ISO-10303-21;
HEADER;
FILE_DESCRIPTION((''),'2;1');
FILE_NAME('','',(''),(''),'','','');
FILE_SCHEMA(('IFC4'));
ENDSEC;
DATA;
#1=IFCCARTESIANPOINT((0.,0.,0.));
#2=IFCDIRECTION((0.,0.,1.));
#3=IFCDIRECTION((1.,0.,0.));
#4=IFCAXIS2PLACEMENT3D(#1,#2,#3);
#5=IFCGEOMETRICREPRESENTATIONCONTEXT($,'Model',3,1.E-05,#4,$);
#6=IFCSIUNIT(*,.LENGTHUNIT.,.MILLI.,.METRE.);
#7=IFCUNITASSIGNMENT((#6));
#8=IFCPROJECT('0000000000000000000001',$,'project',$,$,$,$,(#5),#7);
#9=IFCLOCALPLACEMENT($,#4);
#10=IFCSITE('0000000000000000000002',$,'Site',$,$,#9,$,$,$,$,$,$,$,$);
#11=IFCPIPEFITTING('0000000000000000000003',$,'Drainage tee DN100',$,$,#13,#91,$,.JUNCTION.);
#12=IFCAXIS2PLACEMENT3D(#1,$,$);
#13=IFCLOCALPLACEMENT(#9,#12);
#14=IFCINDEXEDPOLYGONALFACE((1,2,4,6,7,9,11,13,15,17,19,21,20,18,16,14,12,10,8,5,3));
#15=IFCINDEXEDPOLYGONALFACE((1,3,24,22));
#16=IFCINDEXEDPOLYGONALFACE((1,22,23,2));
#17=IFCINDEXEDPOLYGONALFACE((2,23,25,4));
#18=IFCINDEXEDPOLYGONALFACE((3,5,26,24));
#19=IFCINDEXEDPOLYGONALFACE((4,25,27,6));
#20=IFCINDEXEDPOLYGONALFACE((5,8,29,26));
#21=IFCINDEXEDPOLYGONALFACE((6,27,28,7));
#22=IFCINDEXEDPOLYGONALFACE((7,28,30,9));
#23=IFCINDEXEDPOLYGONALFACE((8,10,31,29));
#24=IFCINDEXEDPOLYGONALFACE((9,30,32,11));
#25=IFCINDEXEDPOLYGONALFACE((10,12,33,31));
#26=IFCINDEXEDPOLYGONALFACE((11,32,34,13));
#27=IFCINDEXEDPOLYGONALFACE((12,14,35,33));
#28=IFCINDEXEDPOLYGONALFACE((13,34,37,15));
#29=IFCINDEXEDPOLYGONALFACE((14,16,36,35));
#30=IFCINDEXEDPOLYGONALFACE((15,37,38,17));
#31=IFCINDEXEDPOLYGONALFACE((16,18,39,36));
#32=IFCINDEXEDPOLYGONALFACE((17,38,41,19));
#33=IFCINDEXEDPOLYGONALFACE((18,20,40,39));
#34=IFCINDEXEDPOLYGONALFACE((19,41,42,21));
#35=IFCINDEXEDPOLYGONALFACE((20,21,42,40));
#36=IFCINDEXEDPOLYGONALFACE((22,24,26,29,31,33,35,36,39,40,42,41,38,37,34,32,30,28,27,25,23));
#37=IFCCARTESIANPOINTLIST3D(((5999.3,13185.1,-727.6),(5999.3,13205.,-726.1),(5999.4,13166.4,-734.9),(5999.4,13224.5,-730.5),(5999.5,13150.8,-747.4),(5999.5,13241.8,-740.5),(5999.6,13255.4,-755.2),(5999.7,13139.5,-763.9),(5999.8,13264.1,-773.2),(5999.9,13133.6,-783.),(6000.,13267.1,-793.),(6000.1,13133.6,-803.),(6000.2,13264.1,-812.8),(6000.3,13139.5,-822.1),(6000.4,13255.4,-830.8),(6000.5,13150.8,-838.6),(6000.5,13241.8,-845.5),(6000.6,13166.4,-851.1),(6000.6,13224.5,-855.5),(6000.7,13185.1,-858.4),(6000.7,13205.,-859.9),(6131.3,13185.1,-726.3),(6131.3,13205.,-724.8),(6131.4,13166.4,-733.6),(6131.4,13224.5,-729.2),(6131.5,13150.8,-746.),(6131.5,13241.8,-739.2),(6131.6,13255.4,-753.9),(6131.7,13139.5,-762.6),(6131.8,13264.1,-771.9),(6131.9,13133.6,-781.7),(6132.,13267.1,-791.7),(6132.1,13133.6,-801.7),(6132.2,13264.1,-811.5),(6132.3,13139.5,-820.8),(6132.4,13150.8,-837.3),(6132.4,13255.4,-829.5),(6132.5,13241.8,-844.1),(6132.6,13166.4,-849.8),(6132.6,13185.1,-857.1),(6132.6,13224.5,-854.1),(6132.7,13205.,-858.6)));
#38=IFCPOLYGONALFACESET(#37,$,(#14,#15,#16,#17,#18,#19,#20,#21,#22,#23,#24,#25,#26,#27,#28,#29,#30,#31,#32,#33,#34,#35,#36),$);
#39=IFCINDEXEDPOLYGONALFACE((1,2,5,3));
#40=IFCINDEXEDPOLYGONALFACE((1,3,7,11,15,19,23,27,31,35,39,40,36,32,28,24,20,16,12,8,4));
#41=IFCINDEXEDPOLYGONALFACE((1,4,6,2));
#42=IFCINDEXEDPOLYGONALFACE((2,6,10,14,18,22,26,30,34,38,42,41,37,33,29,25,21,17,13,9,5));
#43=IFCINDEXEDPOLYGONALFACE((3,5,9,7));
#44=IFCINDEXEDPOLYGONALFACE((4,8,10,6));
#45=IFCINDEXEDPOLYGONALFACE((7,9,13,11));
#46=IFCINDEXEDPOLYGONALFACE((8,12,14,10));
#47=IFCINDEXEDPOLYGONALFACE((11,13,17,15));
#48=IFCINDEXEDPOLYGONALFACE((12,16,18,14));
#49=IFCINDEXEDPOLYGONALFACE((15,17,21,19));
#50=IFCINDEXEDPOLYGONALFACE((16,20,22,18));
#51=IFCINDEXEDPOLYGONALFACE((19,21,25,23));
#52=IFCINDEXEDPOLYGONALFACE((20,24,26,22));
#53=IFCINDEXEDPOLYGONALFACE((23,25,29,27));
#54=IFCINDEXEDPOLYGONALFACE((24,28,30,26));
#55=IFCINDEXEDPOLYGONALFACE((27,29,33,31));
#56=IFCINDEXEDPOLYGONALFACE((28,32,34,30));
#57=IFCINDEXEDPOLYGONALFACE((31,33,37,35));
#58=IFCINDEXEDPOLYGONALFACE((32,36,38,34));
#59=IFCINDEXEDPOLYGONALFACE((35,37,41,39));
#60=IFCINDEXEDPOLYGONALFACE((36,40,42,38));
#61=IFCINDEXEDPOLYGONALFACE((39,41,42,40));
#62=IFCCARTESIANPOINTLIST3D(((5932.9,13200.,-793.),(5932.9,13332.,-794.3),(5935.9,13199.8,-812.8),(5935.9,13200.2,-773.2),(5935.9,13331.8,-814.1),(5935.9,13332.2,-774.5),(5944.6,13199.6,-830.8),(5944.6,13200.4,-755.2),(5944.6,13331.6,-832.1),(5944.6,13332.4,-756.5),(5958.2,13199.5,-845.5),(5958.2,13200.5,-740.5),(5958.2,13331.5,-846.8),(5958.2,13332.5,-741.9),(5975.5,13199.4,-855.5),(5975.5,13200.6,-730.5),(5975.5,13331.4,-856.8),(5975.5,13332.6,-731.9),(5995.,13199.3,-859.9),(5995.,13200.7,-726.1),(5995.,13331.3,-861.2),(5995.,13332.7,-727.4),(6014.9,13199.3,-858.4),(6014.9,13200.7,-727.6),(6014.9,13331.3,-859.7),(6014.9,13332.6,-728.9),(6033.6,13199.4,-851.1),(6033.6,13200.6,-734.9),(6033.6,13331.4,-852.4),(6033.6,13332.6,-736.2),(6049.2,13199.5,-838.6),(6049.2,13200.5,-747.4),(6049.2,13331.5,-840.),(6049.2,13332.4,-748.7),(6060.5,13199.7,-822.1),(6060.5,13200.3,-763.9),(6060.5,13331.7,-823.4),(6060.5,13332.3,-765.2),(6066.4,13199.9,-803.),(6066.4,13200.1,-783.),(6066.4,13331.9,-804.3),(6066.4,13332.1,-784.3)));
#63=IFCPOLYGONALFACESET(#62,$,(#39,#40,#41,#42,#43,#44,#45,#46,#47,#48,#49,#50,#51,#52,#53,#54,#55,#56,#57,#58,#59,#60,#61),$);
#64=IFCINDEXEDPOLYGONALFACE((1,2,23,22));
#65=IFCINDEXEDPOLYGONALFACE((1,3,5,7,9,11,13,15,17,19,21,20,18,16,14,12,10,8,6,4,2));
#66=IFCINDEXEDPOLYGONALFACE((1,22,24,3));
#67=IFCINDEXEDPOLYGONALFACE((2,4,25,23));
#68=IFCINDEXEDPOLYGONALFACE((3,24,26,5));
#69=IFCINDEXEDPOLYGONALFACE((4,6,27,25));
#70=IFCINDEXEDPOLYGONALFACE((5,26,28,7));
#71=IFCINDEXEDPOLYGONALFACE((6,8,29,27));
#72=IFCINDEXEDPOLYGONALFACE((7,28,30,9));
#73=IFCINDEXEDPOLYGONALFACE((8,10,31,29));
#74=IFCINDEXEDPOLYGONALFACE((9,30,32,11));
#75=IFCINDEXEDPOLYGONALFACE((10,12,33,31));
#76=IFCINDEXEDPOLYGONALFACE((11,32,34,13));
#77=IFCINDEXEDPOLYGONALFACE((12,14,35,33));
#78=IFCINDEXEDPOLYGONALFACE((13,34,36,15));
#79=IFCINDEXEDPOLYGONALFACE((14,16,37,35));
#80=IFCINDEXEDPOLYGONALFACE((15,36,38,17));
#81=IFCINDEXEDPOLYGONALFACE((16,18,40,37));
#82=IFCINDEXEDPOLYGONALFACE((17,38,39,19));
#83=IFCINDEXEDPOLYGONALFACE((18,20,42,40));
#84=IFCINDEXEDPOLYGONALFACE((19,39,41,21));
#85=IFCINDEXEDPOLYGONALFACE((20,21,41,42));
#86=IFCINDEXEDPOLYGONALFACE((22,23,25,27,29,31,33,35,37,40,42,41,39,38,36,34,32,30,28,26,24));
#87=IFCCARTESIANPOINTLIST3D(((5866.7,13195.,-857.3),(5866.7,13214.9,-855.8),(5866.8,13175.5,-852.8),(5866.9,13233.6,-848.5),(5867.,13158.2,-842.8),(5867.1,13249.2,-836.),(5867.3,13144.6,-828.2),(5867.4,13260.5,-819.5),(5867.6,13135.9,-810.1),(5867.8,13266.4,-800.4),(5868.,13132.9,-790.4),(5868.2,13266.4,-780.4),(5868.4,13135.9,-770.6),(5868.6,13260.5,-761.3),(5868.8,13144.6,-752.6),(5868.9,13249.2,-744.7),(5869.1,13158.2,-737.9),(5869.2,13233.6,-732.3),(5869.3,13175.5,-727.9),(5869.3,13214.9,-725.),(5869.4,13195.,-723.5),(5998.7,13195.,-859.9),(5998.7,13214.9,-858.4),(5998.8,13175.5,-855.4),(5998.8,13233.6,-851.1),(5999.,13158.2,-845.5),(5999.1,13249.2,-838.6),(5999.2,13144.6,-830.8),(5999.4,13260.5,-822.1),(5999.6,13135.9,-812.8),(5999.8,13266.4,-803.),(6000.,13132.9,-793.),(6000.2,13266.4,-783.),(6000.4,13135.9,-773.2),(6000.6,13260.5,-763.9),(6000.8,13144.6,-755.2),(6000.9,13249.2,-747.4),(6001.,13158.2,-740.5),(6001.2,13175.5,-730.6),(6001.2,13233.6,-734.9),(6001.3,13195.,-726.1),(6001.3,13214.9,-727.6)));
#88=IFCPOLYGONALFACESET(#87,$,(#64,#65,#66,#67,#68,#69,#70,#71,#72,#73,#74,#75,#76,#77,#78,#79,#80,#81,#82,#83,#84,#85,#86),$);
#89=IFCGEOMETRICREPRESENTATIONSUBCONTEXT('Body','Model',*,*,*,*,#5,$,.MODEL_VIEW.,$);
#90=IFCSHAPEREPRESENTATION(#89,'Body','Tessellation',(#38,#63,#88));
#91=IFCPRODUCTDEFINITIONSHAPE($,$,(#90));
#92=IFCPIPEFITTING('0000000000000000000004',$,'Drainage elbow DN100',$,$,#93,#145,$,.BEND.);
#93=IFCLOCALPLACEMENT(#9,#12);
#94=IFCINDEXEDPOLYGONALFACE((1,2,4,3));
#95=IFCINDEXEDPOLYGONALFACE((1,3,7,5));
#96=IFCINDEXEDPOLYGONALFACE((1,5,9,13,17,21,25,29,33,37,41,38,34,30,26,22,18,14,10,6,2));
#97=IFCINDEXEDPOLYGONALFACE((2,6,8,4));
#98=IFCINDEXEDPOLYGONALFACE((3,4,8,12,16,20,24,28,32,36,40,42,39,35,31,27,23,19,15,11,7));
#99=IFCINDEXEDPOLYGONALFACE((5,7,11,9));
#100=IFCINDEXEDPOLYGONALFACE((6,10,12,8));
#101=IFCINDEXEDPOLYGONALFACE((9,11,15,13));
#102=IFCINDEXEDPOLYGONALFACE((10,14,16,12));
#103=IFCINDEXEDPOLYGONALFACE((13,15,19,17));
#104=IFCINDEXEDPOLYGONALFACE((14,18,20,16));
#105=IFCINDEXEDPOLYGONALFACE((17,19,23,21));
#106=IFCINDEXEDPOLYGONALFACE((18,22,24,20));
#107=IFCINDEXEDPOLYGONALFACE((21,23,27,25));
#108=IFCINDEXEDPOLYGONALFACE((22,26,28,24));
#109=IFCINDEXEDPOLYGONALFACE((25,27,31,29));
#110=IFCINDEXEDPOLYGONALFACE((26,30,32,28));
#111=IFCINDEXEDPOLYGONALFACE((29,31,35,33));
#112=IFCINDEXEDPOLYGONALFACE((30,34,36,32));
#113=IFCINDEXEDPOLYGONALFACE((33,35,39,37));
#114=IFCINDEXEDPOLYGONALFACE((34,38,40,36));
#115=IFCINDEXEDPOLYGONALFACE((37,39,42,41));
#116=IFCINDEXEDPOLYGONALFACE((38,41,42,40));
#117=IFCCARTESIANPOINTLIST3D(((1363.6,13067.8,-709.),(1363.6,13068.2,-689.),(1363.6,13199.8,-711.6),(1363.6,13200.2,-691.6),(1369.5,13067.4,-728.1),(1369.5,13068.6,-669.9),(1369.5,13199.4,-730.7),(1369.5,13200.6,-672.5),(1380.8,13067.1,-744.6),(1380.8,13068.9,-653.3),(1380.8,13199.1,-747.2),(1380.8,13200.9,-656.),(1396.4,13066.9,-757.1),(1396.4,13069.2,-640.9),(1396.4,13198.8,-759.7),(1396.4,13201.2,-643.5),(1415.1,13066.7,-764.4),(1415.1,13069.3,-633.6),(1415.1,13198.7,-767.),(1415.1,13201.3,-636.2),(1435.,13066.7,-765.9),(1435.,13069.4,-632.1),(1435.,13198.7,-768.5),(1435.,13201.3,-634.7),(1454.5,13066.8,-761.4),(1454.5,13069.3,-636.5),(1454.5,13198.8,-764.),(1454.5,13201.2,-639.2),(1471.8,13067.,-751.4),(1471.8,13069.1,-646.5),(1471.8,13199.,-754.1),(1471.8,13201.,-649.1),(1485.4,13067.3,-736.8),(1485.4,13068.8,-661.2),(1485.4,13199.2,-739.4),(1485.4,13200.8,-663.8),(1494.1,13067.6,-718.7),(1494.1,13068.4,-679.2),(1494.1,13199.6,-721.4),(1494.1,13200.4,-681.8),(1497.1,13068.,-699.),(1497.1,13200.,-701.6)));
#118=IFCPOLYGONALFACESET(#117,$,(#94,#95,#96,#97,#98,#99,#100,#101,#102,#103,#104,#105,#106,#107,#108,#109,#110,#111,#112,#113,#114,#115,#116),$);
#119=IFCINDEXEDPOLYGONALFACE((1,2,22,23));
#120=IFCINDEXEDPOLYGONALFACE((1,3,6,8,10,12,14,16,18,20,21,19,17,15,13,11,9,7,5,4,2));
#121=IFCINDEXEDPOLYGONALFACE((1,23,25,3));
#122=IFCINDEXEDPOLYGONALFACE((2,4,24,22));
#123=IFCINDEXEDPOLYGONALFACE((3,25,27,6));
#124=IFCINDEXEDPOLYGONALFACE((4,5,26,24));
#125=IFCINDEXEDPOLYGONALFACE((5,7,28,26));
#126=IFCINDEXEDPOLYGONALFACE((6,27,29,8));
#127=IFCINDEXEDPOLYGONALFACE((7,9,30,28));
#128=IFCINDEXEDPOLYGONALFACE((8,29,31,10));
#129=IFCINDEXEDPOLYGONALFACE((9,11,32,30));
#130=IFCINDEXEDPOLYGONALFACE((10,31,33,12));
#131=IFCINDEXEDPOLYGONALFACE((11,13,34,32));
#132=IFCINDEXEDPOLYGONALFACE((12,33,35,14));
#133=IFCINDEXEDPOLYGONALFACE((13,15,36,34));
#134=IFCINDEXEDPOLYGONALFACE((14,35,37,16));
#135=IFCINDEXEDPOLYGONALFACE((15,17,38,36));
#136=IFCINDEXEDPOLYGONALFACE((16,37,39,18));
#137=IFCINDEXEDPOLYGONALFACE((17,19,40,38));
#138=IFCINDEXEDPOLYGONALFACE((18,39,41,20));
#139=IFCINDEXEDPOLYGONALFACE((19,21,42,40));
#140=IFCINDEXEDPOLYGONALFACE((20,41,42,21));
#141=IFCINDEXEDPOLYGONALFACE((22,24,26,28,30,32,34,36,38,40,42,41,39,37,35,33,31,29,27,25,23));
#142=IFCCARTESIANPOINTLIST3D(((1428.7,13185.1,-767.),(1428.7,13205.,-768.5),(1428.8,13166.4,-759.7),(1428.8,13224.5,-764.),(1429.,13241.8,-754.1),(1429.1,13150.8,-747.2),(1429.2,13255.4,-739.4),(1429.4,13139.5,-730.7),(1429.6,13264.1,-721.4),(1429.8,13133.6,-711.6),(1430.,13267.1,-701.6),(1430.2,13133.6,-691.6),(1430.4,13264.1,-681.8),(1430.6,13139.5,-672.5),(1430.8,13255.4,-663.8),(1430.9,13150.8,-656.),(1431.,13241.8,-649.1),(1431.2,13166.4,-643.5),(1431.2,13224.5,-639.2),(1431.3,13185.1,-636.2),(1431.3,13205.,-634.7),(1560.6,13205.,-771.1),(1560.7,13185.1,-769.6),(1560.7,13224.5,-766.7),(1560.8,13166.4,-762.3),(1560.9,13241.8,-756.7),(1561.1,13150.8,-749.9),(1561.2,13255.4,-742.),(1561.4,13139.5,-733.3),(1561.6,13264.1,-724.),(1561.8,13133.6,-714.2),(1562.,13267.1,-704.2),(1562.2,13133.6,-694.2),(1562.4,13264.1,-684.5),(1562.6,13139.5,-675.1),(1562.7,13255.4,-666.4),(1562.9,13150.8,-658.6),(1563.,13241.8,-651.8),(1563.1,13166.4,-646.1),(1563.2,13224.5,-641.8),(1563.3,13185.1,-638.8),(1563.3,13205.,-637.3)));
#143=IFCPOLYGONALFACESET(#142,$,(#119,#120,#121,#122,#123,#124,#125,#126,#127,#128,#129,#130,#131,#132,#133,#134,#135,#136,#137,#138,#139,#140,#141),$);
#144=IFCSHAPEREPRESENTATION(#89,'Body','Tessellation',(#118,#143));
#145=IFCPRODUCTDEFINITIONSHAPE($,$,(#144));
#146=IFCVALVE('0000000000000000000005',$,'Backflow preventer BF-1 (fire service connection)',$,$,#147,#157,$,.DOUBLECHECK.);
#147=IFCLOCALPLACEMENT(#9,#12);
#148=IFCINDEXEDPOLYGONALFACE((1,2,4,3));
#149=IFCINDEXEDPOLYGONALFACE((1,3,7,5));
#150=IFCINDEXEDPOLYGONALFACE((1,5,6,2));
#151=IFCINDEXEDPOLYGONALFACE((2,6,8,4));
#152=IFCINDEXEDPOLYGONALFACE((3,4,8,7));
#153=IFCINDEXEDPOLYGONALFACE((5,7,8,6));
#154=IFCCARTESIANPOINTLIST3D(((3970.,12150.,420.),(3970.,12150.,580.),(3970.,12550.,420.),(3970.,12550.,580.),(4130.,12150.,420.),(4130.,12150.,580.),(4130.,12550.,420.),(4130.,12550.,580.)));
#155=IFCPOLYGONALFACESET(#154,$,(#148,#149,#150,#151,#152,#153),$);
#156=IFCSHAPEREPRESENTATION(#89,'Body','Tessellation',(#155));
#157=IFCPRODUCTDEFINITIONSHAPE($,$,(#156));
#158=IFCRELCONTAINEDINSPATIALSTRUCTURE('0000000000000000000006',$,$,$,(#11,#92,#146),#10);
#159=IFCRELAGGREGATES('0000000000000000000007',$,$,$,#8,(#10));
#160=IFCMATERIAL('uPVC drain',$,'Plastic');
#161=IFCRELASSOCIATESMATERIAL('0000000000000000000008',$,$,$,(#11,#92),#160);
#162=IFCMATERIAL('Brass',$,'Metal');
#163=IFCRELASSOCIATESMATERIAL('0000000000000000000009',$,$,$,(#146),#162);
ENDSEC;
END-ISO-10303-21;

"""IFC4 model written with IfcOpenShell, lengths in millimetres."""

from ifc_helpers import new_model, si_unit, frame, origin_with_axes, origin_2d, place, context, subcontext, project, spatial, rectangle, circle, extrude, material, element, save


model = new_model("IFC4")

# Units and contexts
model_context = context("Model", 3, precision=1e-05, world=origin_with_axes())
body_context = subcontext(model_context, "Body", "Model", "MODEL_VIEW")
ifc_project = project(units=[si_unit("LENGTHUNIT", "METRE", prefix="MILLI")], contexts=[model_context])

# Site
site_placement = place(None, origin_with_axes())
site = spatial("IfcSite", under=ifc_project, at=site_placement, Name="Site")

# Shared definitions
ifc_material_1 = material(Name="Brass", Category="Metal")
placement_1 = place(site_placement, origin_with_axes())
placement_2 = place(placement_1, origin_with_axes())

# Shared definitions
ifc_material_2 = material(Name="uPVC drain", Category="Plastic")

# Pipe fittings
pipe_fitting_1_placement = place(placement_2, frame((6000.0, 13200.0, -793.0)))
element("IfcPipeFitting", 1, at=pipe_fitting_1_placement, inside=site, material=ifc_material_2, Name="Drainage tee DN100", PredefinedType="JUNCTION", context=body_context, shape_type="SweptSolid", body=[
    extrude(circle(Radius=67.1, at=origin_2d()), frame((0.0, 0.0, 0.0), z_axis=(0.99995, 0.0, 0.009999), x_axis=(0.0, 1.0, 0.0)), (0.0, 0.0, 1.0), 132.0),
    extrude(circle(Radius=67.1, at=origin_2d()), frame((0.0, 0.0, 0.0), z_axis=(0.0, 0.99995, -0.009999), x_axis=(-1.0, 0.0, 0.0)), (0.0, 0.0, 1.0), 132.0),
    extrude(circle(Radius=67.1, at=origin_2d()), frame((0.0, 0.0, 0.0), z_axis=(-0.9998, 0.0, 0.019996), x_axis=(0.0, -1.0, 0.0)), (0.0, 0.0, 1.0), 132.0),
])
pipe_fitting_2_placement = place(placement_2, frame((1430.0, 13200.0, -701.6)))
element("IfcPipeFitting", 2, at=pipe_fitting_2_placement, inside=site, material=ifc_material_2, Name="Drainage elbow DN100", PredefinedType="BEND", context=body_context, shape_type="SweptSolid", body=[
    extrude(circle(Radius=67.1, at=origin_2d()), frame((0.0, 0.0, 0.0), z_axis=(0.0, -0.9998, 0.019996), x_axis=(1.0, 0.0, 0.0)), (0.0, 0.0, 1.0), 132.0),
    extrude(circle(Radius=67.1, at=origin_2d()), frame((0.0, 0.0, 0.0), z_axis=(0.9998, 0.0, -0.019996), x_axis=(0.0, 1.0, 0.0)), (0.0, 0.0, 1.0), 132.0),
])

# Valve
valve_placement = place(placement_2, frame((4050.0, 12350.0, 0.0)))
element("IfcValve", 3, at=valve_placement, inside=site, material=ifc_material_1, Name="Backflow preventer BF-1 (fire service connection)", PredefinedType="DOUBLECHECK", context=body_context, shape_type="SweptSolid", body=[
    extrude(rectangle(XDim=160.0, YDim=400.0, at=origin_2d()), frame((0.0, 0.0, 420.0)), (0.0, 0.0, 1.0), 160.0),
])

save(model, "model.ifc")
